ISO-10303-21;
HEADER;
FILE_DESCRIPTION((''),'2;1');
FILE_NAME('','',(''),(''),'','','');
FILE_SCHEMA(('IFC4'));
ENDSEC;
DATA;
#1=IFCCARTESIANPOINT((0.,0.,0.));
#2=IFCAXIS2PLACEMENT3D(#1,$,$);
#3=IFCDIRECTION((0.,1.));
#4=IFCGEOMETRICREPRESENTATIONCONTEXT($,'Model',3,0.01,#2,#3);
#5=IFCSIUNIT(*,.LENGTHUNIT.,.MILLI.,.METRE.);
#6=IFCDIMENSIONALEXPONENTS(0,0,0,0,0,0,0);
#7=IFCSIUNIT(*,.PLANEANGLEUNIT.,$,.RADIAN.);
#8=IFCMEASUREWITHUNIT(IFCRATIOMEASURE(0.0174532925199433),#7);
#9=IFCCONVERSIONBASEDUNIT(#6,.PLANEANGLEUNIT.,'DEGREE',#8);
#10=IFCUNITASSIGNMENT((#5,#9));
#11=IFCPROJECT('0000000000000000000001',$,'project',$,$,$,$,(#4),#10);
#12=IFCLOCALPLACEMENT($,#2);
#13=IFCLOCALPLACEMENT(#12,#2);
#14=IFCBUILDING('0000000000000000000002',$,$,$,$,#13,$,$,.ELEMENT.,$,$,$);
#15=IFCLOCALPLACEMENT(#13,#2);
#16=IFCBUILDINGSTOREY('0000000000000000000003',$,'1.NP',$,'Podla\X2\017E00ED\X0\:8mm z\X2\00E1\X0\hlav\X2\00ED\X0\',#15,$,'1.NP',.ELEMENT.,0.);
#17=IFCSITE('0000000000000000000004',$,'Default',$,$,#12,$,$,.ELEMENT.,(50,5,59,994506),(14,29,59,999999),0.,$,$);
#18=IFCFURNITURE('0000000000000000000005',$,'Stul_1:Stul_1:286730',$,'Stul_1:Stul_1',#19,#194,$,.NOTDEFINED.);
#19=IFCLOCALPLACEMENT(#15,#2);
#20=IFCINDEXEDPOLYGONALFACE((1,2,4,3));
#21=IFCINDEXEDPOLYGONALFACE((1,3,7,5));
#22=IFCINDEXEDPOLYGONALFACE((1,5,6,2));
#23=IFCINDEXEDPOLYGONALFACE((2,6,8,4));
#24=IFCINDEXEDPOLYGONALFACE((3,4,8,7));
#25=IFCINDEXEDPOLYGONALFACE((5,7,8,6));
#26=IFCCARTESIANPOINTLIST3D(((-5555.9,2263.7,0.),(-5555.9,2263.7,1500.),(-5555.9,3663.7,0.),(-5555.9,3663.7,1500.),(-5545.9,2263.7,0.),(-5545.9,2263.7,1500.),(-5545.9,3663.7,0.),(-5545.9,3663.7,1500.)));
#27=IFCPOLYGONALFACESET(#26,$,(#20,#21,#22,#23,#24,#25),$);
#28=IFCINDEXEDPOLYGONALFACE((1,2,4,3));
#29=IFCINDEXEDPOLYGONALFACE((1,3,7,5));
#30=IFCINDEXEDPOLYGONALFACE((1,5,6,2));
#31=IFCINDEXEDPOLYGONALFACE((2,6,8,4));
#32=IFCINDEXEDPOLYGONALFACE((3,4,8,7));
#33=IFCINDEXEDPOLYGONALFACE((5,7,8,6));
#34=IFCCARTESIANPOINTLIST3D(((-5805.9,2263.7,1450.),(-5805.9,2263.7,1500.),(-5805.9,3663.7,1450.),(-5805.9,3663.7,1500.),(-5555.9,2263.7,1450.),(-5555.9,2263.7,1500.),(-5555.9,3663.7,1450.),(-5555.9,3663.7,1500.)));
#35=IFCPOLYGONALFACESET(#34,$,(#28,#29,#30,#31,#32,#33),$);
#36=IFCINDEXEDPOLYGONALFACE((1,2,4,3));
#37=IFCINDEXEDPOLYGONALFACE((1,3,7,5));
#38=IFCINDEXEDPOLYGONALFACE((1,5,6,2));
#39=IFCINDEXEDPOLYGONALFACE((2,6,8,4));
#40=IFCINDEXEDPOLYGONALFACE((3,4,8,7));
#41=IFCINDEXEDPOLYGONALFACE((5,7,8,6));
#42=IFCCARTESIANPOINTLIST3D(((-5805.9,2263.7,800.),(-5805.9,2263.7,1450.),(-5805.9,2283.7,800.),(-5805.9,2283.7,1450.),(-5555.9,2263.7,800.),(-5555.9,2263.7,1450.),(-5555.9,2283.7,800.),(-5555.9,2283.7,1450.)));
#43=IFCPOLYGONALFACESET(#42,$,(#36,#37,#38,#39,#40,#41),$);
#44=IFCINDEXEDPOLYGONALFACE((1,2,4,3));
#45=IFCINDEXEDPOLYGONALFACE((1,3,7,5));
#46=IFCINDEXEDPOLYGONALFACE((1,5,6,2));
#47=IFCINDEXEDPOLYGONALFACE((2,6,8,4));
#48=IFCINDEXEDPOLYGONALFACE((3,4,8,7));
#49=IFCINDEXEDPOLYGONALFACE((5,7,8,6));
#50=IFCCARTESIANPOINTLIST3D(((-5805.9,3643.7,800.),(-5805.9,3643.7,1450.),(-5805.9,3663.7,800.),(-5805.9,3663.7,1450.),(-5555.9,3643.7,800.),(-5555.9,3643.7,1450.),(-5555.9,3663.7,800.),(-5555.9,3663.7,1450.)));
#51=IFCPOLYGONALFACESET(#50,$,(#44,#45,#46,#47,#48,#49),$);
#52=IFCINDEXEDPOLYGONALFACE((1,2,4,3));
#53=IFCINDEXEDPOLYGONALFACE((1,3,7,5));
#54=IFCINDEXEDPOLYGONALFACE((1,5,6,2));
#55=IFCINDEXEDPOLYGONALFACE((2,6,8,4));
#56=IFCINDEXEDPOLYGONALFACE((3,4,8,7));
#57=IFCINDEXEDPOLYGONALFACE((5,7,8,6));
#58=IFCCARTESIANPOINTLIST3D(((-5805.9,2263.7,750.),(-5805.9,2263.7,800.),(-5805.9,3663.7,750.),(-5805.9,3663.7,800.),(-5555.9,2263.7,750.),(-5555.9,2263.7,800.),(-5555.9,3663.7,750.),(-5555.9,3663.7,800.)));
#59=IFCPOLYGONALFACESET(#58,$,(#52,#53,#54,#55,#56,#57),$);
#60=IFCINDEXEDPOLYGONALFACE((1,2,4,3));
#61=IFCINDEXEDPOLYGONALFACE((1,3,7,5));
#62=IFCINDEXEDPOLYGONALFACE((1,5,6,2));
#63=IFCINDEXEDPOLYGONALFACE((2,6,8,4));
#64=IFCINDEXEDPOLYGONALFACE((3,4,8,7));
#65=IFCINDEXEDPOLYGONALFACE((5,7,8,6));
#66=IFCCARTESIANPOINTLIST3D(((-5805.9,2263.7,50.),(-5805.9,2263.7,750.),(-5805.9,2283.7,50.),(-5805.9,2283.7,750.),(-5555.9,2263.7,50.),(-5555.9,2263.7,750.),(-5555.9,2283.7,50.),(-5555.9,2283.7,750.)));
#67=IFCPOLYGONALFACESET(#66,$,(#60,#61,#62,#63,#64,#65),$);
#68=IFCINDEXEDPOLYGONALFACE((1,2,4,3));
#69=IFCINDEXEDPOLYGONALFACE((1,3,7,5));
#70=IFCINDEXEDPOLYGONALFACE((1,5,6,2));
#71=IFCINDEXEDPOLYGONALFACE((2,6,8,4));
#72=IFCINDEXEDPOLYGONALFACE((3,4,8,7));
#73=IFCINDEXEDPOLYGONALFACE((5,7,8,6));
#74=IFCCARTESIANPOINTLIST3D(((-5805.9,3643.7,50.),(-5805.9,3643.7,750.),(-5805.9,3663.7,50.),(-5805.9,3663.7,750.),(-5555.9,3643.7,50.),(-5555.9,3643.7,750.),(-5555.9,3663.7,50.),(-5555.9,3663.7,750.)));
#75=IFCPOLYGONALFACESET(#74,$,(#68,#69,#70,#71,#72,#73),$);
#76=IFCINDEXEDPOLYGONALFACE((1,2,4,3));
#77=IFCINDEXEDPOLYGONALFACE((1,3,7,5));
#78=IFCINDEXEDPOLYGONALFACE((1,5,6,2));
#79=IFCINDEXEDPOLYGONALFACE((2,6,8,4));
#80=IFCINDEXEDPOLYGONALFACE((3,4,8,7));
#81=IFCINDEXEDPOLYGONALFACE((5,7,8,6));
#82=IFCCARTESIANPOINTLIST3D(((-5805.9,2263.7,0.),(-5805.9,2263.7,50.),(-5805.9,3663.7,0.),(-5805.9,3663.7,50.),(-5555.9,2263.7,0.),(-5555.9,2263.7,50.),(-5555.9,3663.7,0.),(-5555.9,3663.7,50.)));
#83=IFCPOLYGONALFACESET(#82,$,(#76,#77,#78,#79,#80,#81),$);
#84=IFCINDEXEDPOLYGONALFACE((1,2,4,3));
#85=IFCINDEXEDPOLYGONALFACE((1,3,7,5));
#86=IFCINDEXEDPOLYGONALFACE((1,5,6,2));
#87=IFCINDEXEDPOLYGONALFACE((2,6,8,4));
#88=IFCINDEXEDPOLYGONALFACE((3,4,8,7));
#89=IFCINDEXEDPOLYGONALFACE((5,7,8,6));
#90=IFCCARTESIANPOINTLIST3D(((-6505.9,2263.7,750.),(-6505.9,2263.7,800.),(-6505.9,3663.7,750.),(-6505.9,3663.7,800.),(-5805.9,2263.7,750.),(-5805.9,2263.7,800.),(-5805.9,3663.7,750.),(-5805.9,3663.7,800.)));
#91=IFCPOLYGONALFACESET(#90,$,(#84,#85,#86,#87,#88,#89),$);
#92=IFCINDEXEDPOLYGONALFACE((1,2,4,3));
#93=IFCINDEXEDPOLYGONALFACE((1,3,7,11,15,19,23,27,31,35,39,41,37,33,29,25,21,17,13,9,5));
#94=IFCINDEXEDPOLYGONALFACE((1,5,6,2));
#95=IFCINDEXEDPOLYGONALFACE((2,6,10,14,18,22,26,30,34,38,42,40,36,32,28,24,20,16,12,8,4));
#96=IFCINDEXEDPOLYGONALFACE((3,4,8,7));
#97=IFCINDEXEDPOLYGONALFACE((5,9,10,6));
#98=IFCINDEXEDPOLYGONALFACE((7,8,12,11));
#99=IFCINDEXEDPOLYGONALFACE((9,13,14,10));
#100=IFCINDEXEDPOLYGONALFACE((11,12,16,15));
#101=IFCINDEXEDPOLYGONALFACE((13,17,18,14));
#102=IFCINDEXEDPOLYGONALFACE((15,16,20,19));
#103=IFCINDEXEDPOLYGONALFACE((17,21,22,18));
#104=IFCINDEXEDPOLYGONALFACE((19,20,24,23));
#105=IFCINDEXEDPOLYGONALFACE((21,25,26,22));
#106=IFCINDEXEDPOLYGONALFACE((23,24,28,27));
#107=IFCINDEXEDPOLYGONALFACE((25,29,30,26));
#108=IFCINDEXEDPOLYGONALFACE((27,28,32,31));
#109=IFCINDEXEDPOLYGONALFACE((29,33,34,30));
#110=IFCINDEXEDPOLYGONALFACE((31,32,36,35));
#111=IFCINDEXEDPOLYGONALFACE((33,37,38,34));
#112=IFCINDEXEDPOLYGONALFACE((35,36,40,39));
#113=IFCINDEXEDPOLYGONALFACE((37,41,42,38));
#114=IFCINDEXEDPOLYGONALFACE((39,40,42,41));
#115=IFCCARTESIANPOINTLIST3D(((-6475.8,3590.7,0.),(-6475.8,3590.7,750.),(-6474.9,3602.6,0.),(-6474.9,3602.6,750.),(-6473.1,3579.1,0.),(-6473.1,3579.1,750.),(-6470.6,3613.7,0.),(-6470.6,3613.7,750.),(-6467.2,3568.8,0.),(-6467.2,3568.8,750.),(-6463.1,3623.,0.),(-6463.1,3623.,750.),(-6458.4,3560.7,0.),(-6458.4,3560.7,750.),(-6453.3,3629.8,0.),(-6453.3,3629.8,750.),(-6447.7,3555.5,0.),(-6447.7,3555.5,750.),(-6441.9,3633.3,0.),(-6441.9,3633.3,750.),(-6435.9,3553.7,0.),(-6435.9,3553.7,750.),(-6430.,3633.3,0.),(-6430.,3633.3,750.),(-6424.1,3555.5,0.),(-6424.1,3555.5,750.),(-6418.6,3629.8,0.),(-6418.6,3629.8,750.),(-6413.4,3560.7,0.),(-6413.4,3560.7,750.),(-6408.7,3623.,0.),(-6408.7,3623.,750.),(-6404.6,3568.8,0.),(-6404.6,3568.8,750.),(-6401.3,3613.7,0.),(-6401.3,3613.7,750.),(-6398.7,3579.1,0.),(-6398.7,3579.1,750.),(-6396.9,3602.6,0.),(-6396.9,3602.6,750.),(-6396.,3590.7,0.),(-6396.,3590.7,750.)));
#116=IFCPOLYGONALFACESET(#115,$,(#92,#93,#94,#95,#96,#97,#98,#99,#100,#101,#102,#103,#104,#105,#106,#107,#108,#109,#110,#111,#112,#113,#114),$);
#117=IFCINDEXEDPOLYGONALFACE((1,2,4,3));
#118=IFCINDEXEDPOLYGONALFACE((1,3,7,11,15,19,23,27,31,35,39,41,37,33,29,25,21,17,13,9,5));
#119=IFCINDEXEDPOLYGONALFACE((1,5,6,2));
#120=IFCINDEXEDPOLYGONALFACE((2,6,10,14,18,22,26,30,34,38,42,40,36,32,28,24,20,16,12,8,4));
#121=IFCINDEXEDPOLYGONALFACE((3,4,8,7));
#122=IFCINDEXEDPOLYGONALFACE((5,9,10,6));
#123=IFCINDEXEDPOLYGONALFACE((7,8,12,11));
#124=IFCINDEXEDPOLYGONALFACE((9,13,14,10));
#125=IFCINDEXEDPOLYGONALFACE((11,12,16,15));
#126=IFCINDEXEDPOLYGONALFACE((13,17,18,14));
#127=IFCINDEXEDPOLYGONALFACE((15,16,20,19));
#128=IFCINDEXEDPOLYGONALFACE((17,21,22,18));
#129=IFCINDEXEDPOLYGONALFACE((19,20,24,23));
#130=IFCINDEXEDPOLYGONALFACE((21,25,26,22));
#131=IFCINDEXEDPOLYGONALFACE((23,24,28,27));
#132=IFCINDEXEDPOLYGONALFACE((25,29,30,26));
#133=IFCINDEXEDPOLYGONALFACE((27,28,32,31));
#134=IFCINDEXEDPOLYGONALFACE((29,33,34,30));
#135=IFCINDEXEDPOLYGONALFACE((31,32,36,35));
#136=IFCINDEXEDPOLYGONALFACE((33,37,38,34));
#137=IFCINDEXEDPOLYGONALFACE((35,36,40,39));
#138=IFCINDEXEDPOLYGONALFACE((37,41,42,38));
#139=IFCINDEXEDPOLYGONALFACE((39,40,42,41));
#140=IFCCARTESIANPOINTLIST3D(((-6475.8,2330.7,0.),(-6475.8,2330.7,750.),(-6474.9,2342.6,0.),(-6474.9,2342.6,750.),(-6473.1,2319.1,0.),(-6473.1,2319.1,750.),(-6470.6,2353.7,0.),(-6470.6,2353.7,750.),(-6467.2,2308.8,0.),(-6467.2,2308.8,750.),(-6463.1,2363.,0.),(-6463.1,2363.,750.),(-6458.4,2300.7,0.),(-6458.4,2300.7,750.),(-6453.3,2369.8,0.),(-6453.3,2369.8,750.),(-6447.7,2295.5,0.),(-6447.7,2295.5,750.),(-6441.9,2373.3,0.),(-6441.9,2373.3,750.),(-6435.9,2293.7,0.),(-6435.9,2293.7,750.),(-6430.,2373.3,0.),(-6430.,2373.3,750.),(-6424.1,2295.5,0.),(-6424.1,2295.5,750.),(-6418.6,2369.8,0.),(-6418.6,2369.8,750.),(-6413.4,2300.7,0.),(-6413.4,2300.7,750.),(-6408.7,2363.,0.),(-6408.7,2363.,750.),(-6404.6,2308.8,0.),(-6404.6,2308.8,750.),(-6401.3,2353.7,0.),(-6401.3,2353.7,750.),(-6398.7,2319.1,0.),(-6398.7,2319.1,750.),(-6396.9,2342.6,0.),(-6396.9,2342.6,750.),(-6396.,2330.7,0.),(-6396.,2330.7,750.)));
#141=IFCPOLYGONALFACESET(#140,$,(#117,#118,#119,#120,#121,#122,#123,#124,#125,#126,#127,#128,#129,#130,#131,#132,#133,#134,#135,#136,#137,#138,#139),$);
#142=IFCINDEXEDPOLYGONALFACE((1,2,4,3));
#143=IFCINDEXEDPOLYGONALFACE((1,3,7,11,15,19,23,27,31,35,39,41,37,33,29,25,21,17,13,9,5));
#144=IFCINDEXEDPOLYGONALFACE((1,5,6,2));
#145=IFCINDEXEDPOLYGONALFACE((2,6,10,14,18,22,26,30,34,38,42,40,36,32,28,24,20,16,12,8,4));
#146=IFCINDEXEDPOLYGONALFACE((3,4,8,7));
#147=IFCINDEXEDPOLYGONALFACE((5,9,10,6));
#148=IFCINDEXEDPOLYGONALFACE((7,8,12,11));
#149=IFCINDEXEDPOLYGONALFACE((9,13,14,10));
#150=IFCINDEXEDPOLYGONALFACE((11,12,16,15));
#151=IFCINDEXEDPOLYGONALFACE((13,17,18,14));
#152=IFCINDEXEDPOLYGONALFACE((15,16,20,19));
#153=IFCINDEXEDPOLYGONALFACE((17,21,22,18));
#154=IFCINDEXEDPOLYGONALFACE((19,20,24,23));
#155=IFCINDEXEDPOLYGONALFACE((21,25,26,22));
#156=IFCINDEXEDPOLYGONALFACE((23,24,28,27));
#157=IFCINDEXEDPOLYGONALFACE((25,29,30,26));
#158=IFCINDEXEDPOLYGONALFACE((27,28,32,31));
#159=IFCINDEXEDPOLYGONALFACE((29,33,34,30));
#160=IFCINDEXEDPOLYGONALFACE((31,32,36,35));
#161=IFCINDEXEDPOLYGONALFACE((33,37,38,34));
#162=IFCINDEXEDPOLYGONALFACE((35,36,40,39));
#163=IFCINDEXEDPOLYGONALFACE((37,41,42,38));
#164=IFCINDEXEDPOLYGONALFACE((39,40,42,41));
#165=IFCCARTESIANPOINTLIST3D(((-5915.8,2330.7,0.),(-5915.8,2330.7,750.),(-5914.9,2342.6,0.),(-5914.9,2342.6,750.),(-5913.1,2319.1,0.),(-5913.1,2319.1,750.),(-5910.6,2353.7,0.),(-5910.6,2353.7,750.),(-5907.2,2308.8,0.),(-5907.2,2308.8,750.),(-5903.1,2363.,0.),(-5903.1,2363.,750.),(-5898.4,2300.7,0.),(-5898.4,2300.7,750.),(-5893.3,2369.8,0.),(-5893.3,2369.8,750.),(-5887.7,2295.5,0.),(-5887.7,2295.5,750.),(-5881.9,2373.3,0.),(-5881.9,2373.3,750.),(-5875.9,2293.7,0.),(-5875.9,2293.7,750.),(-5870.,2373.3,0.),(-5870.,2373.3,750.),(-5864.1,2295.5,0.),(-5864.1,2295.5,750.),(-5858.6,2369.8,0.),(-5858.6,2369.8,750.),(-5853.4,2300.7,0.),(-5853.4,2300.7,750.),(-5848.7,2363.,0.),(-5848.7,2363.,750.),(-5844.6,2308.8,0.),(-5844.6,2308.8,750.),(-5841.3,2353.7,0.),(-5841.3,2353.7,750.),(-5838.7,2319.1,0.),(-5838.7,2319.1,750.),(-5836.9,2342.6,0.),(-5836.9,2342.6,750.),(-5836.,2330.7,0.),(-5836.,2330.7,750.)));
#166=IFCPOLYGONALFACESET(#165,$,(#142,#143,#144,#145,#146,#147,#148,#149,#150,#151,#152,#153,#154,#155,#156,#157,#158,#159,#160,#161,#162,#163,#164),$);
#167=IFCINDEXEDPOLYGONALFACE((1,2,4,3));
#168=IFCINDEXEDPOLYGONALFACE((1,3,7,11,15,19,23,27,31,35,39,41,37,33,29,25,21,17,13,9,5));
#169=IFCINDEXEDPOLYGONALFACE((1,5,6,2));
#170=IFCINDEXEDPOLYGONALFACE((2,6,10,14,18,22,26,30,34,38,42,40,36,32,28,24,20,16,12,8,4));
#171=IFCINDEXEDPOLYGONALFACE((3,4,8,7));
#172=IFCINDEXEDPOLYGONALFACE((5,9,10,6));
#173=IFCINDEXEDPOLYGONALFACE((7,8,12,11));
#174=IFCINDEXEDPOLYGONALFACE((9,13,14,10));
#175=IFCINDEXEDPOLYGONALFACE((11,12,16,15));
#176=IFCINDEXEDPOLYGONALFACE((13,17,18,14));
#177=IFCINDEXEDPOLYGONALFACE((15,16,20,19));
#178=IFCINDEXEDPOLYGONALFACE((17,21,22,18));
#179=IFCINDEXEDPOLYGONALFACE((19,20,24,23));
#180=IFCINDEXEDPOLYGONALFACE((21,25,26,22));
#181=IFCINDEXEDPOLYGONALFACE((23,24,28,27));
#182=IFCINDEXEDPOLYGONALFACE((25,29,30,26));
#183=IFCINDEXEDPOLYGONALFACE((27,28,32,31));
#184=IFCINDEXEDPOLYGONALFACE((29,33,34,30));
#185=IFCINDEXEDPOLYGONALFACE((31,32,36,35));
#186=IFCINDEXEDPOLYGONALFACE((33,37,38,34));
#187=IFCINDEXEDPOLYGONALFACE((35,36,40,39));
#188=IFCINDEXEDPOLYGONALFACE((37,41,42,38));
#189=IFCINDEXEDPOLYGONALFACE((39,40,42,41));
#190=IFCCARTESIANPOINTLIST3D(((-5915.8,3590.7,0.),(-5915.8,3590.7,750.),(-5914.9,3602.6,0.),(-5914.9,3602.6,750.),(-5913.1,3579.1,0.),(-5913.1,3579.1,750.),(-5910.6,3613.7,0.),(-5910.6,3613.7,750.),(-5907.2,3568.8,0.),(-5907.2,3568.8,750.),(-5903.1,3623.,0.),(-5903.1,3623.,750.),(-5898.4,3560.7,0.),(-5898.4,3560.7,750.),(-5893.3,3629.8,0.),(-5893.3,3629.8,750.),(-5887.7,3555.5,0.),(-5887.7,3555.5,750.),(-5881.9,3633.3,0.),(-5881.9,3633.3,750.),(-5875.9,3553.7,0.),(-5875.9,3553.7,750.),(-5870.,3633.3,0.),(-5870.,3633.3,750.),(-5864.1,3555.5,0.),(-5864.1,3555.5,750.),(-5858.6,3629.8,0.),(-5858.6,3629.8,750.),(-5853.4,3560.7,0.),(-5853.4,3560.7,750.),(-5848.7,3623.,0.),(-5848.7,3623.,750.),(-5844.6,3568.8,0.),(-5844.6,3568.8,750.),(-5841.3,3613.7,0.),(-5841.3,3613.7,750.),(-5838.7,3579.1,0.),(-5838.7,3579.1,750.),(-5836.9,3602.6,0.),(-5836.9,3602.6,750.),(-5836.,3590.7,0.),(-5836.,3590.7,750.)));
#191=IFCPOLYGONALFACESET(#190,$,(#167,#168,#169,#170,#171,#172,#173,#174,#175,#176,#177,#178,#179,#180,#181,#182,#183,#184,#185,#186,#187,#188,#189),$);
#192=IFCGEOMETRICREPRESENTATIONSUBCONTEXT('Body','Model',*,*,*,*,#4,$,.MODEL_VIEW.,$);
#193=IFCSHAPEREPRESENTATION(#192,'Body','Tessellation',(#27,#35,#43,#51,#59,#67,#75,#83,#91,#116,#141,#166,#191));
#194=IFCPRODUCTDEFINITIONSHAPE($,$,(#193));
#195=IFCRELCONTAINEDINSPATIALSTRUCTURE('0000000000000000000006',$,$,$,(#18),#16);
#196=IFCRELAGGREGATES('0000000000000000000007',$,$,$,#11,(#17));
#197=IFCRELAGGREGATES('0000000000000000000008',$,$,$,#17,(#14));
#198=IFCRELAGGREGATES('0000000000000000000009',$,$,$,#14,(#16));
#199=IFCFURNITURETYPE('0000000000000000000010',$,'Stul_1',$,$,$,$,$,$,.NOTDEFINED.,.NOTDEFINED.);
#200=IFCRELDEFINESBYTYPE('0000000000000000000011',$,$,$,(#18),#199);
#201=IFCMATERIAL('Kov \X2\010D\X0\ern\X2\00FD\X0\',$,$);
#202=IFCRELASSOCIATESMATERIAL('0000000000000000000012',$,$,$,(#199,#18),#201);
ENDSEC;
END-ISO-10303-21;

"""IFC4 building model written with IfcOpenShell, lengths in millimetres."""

from ifc_helpers import new_model, entity, si_unit, converted_unit, direction, frame, frame_2d, origin, origin_2d_with_axis, place, context, subcontext, project, spatial, rectangle, circle, extrude, source, transform, mapped, material, type_object, type_shapes, element, save


model = new_model("IFC4")

# Units and contexts
model_context = context("Model", 3, precision=0.01, world=origin(), true_north=direction((0.0, 1.0)))
body_context = subcontext(model_context, "Body", "Model", "MODEL_VIEW")
ifc_project = project(units=[si_unit("LENGTHUNIT", "METRE", prefix="MILLI"), converted_unit("PLANEANGLEUNIT", "DEGREE", entity("IfcRatioMeasure", 0.0174532925199433), si_unit("PLANEANGLEUNIT", "RADIAN"), dimensions=[0, 0, 0, 0, 0, 0, 0])], contexts=[model_context])

# Site, building, storey
site_placement = place(None, origin())
site = spatial("IfcSite", under=ifc_project, at=site_placement, Name="Default", CompositionType="ELEMENT", RefLatitude=(50, 5, 59, 994506), RefLongitude=(14, 29, 59, 999999), RefElevation=0.0)
building_placement = place(site_placement, origin())
building = spatial("IfcBuilding", under=site, at=building_placement, CompositionType="ELEMENT")
storey_placement = place(building_placement, origin())
storey = spatial("IfcBuildingStorey", under=building, at=storey_placement, Name="1.NP", ObjectType="Podlaží:8mm záhlaví", LongName="1.NP", CompositionType="ELEMENT", Elevation=0.0)

# Furniture
ifc_material_1 = material(Name="Kov černý")
furniture_type = type_object("IfcFurnitureType", Name="Stul_1", AssemblyPlace="NOTDEFINED", PredefinedType="NOTDEFINED", material=ifc_material_1)
shared_shape_1 = source(origin(), body_context, "Body", "SweptSolid", [
    extrude(rectangle(XDim=1400.0, YDim=10.0, at=origin_2d_with_axis()), frame((0.0, 605.0, 0.0), z_axis=(0.0, 0.0, 1.0), x_axis=(-1.0, 0.0, 0.0)), (0.0, 0.0, 1.0), 1500.0),
    extrude(rectangle(XDim=1400.0, YDim=250.0, at=frame_2d((0.0, 0.0), x_axis=(1.0, 0.0))), frame((0.0, 475.0, 1450.0), z_axis=(0.0, 0.0, 1.0), x_axis=(-1.0, 0.0, 0.0)), (0.0, 0.0, 1.0), 50.0),
    extrude(rectangle(XDim=20.0, YDim=250.0, at=origin_2d_with_axis()), frame((690.0, 475.0, 800.0), z_axis=(0.0, 0.0, 1.0), x_axis=(-1.0, 0.0, 0.0)), (0.0, 0.0, 1.0), 650.0),
    extrude(rectangle(XDim=20.0, YDim=250.0, at=frame_2d((0.0, 0.0), x_axis=(1.0, 0.0))), frame((-690.0, 475.0, 800.0), z_axis=(0.0, 0.0, 1.0), x_axis=(-1.0, 0.0, 0.0)), (0.0, 0.0, 1.0), 650.0),
    extrude(rectangle(XDim=1400.0, YDim=250.0, at=origin_2d_with_axis()), frame((0.0, 475.0, 750.0), z_axis=(0.0, 0.0, 1.0), x_axis=(-1.0, 0.0, 0.0)), (0.0, 0.0, 1.0), 50.0),
    extrude(rectangle(XDim=20.0, YDim=250.0, at=origin_2d_with_axis()), frame((690.0, 475.0, 50.0), z_axis=(0.0, 0.0, 1.0), x_axis=(-1.0, 0.0, 0.0)), (0.0, 0.0, 1.0), 700.0),
    extrude(rectangle(XDim=20.0, YDim=250.0, at=frame_2d((0.0, 0.0), x_axis=(1.0, 0.0))), frame((-690.0, 475.0, 50.0), z_axis=(0.0, 0.0, 1.0), x_axis=(-1.0, 0.0, 0.0)), (0.0, 0.0, 1.0), 700.0),
    extrude(rectangle(XDim=1400.0, YDim=250.0, at=origin_2d_with_axis()), frame((0.0, 475.0, 0.0), z_axis=(0.0, 0.0, 1.0), x_axis=(-1.0, 0.0, 0.0)), (0.0, 0.0, 1.0), 50.0),
    extrude(rectangle(XDim=1400.0, YDim=700.0, at=origin_2d_with_axis()), frame((0.0, 0.0, 750.0), z_axis=(0.0, 0.0, 1.0), x_axis=(-1.0, 0.0, 0.0)), (0.0, 0.0, 1.0), 50.0),
    extrude(circle(Radius=40.0, at=frame_2d((0.0, 0.0), x_axis=(1.0, 0.0))), frame((-630.0, -280.0, 0.0)), (0.0, 0.0, 1.0), 750.0),
    extrude(circle(Radius=40.0, at=frame_2d((0.0, 0.0), x_axis=(1.0, 0.0))), frame((630.0, -280.0, 0.0)), (0.0, 0.0, 1.0), 750.0),
    extrude(circle(Radius=40.0, at=frame_2d((0.0, 0.0), x_axis=(1.0, 0.0))), frame((630.0, 280.0, 0.0)), (0.0, 0.0, 1.0), 750.0),
    extrude(circle(Radius=40.0, at=frame_2d((0.0, 0.0), x_axis=(1.0, 0.0))), frame((-630.0, 280.0, 0.0)), (0.0, 0.0, 1.0), 750.0),
])
type_shapes(furniture_type, [shared_shape_1])
for number, where, z_axis, x_axis, name in (
    (1, (-6155.9, 2963.7, 0.0), (0.0, 0.0, 1.0), (0.0, -1.0, 0.0), "Stul_1:Stul_1:286730"),
):
    element("IfcFurniture", number, at=place(storey_placement, frame(where, z_axis=z_axis, x_axis=x_axis)), inside=storey, type_object=furniture_type, material=ifc_material_1, Name=name, ObjectType="Stul_1:Stul_1", PredefinedType="NOTDEFINED", context=body_context, shape_type="MappedRepresentation", body=[
        mapped(shared_shape_1, transform((0.0, 0.0, 0.0), scale=1.0)),
    ])

save(model, "model.ifc")
